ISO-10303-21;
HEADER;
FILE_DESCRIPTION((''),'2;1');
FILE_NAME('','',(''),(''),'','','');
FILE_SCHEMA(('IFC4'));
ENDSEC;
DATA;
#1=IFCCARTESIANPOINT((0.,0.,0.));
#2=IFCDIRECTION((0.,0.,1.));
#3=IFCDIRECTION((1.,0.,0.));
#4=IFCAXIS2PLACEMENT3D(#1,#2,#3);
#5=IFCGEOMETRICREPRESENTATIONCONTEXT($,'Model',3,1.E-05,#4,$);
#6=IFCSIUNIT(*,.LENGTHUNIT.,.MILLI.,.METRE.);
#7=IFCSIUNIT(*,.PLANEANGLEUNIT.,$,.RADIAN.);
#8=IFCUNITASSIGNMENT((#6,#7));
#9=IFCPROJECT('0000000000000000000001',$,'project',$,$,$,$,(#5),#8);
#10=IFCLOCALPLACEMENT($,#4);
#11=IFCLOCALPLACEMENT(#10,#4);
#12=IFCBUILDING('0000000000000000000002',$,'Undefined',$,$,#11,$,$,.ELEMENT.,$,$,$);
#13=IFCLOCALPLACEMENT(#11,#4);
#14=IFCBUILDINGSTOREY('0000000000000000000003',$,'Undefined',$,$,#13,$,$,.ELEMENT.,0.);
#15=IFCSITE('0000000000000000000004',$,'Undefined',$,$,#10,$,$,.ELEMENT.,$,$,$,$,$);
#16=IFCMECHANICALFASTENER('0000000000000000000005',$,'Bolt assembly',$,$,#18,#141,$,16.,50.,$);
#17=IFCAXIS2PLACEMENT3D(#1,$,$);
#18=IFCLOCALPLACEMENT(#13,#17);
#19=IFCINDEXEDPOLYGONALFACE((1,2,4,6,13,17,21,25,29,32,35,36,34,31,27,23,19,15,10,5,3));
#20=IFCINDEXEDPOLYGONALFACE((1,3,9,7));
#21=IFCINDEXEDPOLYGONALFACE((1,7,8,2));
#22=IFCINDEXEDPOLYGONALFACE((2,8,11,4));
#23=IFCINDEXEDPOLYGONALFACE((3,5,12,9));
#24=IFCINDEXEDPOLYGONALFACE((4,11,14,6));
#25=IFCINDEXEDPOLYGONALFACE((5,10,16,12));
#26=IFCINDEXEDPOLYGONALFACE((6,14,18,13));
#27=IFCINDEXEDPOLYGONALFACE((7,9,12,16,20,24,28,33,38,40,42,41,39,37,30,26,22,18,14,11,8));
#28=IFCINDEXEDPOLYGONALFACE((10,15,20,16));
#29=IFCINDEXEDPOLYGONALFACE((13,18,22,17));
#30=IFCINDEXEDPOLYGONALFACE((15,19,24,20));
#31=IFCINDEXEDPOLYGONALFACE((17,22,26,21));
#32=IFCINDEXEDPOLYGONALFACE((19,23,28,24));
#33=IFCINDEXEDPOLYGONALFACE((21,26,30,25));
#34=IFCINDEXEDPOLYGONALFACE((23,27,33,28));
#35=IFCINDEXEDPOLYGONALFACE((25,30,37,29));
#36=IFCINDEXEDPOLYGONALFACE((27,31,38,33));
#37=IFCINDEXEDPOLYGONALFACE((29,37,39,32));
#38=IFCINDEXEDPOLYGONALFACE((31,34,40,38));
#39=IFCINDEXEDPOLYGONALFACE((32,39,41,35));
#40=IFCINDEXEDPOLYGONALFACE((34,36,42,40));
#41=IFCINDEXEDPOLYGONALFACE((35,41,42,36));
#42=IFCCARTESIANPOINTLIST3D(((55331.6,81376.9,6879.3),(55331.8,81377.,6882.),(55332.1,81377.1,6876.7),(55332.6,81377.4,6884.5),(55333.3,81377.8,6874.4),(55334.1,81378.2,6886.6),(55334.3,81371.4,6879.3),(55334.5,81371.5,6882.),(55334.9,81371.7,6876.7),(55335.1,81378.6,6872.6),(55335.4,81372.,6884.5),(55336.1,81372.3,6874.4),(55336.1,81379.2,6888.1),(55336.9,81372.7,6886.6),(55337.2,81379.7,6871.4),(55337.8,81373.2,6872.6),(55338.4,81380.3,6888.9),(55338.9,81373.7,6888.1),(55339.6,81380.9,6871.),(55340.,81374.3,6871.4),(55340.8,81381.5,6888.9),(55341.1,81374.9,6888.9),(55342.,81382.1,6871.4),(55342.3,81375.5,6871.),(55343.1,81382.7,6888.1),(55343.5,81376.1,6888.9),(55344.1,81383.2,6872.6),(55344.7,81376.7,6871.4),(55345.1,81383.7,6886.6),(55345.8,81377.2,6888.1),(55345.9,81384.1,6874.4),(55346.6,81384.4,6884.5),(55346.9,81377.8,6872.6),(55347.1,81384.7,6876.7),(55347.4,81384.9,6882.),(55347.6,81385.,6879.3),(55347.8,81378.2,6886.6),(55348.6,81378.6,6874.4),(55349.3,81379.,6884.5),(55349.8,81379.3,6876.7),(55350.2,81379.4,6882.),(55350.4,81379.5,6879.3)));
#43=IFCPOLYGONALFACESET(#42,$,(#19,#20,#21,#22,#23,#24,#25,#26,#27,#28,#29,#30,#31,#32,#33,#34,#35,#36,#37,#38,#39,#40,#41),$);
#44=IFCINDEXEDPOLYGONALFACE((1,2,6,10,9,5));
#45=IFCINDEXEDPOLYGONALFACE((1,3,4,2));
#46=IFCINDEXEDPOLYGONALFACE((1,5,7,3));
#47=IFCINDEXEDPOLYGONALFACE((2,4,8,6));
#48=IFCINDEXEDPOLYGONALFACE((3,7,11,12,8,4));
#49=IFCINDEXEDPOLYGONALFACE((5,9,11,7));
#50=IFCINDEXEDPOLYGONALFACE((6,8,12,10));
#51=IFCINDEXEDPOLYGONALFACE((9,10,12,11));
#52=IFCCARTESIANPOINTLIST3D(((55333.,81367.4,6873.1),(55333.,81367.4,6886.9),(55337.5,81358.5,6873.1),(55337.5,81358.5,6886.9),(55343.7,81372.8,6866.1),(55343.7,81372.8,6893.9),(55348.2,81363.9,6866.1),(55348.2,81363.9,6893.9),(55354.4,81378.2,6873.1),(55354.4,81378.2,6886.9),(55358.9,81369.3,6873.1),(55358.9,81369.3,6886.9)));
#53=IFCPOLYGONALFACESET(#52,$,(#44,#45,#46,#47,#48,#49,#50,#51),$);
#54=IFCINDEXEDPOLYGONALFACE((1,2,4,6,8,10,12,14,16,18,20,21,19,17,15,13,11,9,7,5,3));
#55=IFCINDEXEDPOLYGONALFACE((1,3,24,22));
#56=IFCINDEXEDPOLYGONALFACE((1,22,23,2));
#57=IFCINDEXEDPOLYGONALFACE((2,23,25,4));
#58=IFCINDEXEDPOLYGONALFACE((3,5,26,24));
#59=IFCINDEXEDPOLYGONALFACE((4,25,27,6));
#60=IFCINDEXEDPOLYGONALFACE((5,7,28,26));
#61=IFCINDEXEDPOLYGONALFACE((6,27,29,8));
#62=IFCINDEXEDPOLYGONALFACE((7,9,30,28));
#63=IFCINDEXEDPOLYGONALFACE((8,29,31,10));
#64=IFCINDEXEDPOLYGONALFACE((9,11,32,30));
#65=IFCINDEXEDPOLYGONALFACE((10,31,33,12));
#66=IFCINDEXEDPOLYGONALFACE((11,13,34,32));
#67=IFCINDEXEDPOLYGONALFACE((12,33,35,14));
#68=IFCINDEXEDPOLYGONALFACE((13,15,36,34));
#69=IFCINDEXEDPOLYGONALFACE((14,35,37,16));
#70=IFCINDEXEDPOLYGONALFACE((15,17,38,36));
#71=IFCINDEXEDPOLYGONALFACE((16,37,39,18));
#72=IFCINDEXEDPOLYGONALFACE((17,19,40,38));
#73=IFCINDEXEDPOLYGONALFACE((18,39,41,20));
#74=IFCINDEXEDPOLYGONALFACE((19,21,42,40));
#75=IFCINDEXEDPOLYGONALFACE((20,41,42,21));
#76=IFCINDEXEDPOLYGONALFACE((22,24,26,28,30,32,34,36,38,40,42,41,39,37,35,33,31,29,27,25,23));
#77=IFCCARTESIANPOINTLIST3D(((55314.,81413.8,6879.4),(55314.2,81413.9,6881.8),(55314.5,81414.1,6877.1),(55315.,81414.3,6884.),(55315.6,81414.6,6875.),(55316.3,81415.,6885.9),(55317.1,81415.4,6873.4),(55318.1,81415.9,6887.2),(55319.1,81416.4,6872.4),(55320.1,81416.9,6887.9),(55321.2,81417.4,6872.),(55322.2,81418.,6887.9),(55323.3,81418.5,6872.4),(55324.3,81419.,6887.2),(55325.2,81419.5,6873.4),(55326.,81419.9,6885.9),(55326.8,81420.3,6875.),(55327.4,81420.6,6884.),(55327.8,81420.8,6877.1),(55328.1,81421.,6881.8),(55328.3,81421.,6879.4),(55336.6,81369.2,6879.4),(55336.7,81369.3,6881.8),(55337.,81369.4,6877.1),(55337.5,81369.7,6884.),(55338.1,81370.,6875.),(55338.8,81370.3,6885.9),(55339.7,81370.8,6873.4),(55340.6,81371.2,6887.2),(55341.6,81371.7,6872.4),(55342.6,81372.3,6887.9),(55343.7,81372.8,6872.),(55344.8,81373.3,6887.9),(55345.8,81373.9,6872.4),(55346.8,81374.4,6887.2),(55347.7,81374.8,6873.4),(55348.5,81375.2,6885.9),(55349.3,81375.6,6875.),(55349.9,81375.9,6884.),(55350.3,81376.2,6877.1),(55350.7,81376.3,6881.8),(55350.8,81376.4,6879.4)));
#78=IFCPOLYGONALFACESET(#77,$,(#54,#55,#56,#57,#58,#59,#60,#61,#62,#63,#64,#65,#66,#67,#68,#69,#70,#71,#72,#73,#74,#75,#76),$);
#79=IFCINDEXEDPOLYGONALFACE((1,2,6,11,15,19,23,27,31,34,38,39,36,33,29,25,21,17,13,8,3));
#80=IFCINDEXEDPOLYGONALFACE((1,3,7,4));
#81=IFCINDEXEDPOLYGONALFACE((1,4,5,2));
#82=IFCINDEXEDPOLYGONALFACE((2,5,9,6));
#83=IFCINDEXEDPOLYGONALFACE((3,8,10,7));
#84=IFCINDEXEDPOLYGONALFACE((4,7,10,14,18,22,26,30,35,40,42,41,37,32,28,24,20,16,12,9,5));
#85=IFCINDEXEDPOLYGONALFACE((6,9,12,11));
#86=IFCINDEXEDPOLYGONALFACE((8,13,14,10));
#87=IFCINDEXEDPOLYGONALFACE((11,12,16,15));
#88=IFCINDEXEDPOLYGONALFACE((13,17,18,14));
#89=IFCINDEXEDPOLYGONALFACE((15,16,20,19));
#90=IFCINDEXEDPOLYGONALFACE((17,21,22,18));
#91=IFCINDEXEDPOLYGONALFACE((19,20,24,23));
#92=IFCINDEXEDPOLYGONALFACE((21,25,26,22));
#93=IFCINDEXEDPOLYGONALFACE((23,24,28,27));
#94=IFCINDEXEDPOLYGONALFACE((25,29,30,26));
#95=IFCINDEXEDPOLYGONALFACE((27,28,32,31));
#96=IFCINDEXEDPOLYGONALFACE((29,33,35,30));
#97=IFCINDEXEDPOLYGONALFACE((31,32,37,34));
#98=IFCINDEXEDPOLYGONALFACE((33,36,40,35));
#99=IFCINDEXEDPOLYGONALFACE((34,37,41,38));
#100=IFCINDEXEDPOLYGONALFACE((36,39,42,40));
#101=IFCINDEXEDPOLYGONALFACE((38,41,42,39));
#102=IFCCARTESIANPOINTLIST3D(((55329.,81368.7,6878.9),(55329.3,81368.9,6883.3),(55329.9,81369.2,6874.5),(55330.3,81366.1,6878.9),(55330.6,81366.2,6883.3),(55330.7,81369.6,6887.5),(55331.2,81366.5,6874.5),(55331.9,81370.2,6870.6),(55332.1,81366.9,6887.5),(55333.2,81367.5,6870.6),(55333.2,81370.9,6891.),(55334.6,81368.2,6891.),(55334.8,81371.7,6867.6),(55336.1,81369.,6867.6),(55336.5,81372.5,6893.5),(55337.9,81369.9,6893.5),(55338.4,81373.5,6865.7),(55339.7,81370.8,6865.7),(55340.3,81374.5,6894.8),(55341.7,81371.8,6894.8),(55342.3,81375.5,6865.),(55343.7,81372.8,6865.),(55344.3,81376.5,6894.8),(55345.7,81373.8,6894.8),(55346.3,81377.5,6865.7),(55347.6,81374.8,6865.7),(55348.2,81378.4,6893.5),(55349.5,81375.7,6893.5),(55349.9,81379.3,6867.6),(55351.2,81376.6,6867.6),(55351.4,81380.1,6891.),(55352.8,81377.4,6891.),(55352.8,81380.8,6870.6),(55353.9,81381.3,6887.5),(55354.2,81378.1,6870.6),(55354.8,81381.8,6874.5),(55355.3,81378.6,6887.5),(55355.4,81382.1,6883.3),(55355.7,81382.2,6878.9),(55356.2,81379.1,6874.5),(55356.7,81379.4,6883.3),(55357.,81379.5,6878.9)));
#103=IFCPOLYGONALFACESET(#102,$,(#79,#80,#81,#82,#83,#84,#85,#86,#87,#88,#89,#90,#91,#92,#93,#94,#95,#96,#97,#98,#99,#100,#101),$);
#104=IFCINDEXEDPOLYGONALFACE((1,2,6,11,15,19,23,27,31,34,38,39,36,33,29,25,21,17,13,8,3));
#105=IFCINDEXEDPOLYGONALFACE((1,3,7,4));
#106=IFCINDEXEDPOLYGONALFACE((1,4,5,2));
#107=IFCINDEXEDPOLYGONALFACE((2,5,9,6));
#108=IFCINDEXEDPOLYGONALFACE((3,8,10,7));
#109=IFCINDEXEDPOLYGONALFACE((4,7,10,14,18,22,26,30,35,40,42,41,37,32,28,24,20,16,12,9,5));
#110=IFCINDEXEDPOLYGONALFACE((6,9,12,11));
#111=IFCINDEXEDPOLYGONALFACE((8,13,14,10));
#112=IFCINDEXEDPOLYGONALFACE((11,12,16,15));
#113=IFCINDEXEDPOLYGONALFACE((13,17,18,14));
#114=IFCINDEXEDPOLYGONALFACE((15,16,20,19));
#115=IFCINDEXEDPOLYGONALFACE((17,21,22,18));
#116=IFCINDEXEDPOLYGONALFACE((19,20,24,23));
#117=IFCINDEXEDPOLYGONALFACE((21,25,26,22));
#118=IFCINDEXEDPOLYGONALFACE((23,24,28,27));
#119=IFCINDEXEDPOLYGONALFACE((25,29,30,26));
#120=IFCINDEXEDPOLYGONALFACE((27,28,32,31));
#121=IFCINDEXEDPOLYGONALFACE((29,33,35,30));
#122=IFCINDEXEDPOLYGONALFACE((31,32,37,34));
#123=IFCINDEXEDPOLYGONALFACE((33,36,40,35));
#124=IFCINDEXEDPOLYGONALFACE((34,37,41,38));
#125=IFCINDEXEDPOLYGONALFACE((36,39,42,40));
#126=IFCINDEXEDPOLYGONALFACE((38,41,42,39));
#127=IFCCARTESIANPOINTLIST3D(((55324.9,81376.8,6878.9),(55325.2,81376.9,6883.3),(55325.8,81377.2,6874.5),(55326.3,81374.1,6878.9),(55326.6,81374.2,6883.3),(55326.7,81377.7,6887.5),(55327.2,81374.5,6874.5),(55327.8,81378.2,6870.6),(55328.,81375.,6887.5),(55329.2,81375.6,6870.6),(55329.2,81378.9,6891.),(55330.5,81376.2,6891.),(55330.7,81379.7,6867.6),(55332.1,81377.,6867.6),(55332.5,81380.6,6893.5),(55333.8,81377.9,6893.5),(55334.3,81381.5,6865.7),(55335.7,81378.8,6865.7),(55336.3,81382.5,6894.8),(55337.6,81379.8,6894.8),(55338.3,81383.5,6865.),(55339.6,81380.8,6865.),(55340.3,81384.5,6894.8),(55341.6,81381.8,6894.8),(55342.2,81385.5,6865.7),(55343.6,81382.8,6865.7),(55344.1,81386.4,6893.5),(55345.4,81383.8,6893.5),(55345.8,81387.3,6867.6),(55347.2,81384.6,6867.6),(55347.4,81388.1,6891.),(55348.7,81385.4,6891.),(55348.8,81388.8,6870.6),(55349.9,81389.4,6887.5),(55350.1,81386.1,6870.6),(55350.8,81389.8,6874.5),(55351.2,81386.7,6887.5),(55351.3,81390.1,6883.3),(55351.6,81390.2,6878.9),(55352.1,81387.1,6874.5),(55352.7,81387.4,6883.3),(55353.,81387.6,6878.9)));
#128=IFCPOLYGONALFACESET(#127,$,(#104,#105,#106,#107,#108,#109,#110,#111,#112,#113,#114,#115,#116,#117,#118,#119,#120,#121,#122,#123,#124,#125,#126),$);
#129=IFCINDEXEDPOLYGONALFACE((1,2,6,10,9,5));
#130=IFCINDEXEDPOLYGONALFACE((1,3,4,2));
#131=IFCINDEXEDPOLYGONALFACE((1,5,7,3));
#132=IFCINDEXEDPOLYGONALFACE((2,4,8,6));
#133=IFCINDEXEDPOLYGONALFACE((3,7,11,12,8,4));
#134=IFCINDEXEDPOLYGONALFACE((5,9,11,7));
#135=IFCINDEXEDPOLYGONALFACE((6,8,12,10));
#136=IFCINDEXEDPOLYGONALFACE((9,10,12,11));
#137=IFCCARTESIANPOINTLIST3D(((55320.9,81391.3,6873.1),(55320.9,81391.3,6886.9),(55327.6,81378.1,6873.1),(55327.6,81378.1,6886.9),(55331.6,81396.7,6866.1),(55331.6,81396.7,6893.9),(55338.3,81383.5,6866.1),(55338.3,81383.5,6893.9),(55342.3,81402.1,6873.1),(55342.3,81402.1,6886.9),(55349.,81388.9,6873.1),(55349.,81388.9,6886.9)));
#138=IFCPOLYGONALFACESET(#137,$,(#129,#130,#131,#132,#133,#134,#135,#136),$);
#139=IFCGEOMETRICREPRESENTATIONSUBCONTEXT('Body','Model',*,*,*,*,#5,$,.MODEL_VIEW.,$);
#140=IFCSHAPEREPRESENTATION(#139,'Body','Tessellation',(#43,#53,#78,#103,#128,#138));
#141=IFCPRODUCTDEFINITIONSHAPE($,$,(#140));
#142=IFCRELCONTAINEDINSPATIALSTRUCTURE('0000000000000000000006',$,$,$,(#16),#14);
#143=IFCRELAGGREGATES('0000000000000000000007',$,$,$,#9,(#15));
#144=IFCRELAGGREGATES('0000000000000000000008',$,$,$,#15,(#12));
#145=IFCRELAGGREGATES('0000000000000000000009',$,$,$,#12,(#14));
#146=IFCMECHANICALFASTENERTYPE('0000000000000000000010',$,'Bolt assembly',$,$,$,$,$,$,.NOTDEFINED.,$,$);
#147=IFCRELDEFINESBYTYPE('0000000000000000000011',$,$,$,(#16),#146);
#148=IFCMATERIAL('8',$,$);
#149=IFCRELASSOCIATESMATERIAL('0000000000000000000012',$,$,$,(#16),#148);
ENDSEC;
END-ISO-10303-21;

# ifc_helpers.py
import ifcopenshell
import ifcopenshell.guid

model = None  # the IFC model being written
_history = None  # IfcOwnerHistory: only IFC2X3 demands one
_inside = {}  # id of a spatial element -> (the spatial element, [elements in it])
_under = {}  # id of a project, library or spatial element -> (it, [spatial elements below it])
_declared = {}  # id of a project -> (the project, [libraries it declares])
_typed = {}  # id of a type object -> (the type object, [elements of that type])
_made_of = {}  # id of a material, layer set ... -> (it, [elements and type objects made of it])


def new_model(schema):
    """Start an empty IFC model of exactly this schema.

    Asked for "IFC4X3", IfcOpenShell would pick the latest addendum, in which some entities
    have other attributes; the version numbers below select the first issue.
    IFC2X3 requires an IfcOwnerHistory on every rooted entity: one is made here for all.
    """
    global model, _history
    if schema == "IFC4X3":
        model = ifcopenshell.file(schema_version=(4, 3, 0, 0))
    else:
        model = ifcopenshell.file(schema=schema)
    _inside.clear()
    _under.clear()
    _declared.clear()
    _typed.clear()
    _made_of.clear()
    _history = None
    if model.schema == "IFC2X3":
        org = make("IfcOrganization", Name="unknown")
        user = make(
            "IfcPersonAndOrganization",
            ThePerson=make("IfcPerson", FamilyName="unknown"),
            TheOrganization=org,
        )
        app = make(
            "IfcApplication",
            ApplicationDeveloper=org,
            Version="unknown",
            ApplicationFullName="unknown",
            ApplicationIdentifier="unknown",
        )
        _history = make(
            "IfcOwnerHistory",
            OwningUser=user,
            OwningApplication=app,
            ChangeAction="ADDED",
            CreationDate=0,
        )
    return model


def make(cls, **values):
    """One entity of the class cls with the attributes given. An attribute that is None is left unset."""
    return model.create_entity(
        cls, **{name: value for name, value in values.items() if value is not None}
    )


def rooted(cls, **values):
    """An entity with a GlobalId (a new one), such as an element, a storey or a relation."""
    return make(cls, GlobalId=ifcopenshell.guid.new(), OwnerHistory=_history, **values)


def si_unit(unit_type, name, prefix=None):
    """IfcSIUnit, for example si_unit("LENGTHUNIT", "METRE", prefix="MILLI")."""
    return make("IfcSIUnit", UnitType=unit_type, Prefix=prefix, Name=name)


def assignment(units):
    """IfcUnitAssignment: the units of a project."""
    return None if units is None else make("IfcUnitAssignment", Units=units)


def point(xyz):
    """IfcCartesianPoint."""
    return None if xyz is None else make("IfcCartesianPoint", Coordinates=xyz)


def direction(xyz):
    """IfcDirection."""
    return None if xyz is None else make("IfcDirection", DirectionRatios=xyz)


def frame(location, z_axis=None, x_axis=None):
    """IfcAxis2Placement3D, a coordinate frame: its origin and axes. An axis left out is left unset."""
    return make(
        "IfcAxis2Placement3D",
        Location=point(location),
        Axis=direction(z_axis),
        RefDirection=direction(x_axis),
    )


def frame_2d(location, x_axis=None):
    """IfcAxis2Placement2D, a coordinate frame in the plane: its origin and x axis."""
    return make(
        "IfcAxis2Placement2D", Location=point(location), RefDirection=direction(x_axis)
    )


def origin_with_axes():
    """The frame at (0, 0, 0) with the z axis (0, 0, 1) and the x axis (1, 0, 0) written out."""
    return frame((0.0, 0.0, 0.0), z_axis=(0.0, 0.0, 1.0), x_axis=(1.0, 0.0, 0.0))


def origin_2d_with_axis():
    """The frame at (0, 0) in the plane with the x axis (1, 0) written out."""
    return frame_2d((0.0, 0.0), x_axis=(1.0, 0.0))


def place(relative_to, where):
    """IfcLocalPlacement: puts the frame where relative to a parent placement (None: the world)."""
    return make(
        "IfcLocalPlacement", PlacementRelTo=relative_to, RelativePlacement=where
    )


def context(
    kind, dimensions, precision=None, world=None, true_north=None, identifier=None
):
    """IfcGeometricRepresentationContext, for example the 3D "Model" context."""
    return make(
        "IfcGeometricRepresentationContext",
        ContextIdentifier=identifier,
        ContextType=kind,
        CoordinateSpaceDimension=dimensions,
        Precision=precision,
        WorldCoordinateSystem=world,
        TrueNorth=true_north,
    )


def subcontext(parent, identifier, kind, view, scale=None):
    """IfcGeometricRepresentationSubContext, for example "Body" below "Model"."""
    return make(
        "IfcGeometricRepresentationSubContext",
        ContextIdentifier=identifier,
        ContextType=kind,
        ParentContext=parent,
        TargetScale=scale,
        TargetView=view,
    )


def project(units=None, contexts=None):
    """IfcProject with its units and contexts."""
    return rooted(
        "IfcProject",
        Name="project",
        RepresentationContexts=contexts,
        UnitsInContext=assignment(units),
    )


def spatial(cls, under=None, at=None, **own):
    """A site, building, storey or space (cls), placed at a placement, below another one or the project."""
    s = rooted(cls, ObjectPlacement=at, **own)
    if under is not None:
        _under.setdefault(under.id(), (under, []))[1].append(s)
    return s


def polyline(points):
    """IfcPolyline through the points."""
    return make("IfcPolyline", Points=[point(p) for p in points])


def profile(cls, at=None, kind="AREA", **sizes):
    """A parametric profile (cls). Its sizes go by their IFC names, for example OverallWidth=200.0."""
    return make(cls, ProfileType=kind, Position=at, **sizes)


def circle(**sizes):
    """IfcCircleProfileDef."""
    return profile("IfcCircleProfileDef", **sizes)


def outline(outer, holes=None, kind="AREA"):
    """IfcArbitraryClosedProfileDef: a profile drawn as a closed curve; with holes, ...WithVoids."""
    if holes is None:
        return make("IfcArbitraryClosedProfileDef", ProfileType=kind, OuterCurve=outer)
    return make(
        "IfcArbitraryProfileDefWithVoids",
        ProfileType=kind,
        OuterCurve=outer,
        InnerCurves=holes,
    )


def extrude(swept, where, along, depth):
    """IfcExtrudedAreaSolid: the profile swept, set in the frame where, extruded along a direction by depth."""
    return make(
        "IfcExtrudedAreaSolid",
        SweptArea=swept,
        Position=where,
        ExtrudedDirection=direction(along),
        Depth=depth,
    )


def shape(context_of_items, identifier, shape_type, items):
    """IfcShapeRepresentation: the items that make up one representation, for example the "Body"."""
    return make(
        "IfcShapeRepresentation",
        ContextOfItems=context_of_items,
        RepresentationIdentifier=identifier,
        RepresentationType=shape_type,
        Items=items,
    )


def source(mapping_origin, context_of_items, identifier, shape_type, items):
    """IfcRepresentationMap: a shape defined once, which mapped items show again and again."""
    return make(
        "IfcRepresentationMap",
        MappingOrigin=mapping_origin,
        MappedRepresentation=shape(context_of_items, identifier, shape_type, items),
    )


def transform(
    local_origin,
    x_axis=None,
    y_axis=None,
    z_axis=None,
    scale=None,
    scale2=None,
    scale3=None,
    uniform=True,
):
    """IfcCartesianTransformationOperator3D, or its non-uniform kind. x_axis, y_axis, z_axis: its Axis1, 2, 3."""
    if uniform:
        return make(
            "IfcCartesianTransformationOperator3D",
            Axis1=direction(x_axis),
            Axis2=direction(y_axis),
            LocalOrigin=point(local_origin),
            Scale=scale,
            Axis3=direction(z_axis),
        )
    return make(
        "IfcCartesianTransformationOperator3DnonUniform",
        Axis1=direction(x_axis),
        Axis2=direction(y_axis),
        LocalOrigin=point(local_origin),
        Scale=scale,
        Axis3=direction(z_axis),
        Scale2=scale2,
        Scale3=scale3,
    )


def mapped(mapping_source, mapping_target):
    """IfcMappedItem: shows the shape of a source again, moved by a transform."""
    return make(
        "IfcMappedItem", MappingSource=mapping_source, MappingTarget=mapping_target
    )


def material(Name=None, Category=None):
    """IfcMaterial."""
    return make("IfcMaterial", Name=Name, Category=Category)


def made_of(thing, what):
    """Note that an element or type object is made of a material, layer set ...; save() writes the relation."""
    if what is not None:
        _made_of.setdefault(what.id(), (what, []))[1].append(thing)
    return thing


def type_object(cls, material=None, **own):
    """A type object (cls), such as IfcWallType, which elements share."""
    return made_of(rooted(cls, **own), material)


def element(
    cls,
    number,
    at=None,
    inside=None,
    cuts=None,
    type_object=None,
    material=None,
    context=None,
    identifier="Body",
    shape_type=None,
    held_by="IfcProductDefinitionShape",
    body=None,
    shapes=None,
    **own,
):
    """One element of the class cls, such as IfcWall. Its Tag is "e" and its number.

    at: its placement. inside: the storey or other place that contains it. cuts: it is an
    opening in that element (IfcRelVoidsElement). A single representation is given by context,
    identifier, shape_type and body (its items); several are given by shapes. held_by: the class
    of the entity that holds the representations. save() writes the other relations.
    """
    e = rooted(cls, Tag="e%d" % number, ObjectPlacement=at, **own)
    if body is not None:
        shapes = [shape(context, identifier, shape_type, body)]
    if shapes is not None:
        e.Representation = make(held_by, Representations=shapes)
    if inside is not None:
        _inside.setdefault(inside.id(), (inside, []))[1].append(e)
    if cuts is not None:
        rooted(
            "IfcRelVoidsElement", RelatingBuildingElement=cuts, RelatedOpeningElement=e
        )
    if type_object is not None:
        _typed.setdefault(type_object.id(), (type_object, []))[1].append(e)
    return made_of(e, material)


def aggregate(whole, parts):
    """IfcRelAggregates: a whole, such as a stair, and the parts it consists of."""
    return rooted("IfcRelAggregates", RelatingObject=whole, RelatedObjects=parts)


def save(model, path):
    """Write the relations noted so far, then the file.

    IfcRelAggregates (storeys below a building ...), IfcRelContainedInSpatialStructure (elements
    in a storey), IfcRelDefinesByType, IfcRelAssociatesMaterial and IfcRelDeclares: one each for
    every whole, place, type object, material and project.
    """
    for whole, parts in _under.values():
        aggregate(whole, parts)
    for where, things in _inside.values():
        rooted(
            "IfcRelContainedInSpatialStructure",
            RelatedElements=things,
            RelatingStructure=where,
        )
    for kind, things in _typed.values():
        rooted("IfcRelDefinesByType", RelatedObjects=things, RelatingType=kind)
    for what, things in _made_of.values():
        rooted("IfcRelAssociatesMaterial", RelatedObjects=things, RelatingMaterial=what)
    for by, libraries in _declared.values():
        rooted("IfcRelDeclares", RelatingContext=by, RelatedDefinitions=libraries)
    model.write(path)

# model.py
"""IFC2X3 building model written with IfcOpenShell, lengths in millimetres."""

from ifc_helpers import new_model, si_unit, frame, origin_with_axes, origin_2d_with_axis, place, context, subcontext, project, spatial, polyline, circle, outline, extrude, source, transform, mapped, material, type_object, element, save


model = new_model("IFC2X3")

# Units and contexts
model_context = context("Model", 3, precision=1e-05, world=origin_with_axes())
body_context = subcontext(model_context, "Body", "Model", "MODEL_VIEW")
ifc_project = project(units=[si_unit("LENGTHUNIT", "METRE", prefix="MILLI"), si_unit("PLANEANGLEUNIT", "RADIAN")], contexts=[model_context])

# Site, building, storey
site_placement = place(None, origin_with_axes())
site = spatial("IfcSite", under=ifc_project, at=site_placement, Name="Undefined", CompositionType="ELEMENT")
building_placement = place(site_placement, origin_with_axes())
building = spatial("IfcBuilding", under=site, at=building_placement, Name="Undefined", CompositionType="ELEMENT")
storey_placement = place(building_placement, origin_with_axes())
storey = spatial("IfcBuildingStorey", under=building, at=storey_placement, Name="Undefined", CompositionType="ELEMENT", Elevation=0.0)

# Mechanical fastener
ifc_material_1 = material(Name="8")
mechanical_fastener_type = type_object("IfcMechanicalFastenerType", Name="Bolt assembly")
shared_shape_1 = source(origin_with_axes(), body_context, "Body", "SweptSolid", [
    extrude(circle(Radius=9.0, at=origin_2d_with_axis()), frame((0.0, 0.0, 0.0), z_axis=(0.0, 1.0, 0.0), x_axis=(1.0, 0.0, 0.0)), (0.0, 0.0, 1.0), 6.1),
    extrude(outline(polyline([(13.9, 0.0), (6.9, 12.0), (-6.9, 12.0), (-13.9, 0.0), (-6.9, -12.0), (6.9, -12.0), (13.9, 0.0)])), frame((0.0, -13.0, 0.0), z_axis=(0.0, 1.0, 0.0), x_axis=(1.0, 0.0, 0.0)), (0.0, 0.0, 1.0), 10.0),
    extrude(circle(Radius=8.0, at=origin_2d_with_axis()), frame((0.0, -3.0, 0.0), z_axis=(0.0, 1.0, 0.0), x_axis=(1.0, 0.0, 0.0)), (0.0, 0.0, 1.0), 50.0),
    extrude(circle(Radius=15.0, at=origin_2d_with_axis()), frame((0.0, -3.0, 0.0), z_axis=(0.0, 1.0, 0.0), x_axis=(1.0, 0.0, 0.0)), (0.0, 0.0, 1.0), 3.0),
    extrude(circle(Radius=15.0, at=origin_2d_with_axis()), frame((0.0, 6.0, 0.0), z_axis=(0.0, 1.0, 0.0), x_axis=(1.0, 0.0, 0.0)), (0.0, 0.0, 1.0), 3.0),
    extrude(outline(polyline([(13.9, 0.0), (6.9, 12.0), (-6.9, 12.0), (-13.9, 0.0), (-6.9, -12.0), (6.9, -12.0), (13.9, 0.0)])), frame((0.0, 9.0, 0.0), z_axis=(0.0, 1.0, 0.0), x_axis=(1.0, 0.0, 0.0)), (0.0, 0.0, 1.0), 14.8),
])
mechanical_fastener_1_placement = place(storey_placement, frame((55342.3, 81375.5, 6880.0), z_axis=(0.892821, 0.450411, 0.0), x_axis=(-0.000057, 0.000114, -1.0)))
element("IfcMechanicalFastener", 1, at=mechanical_fastener_1_placement, inside=storey, type_object=mechanical_fastener_type, material=ifc_material_1, Name="Bolt assembly", NominalDiameter=16.0, NominalLength=50.0, context=body_context, shape_type="MappedRepresentation", body=[
    mapped(shared_shape_1, transform((0.0, 0.0, 0.0))),
])

save(model, "model.ifc")
